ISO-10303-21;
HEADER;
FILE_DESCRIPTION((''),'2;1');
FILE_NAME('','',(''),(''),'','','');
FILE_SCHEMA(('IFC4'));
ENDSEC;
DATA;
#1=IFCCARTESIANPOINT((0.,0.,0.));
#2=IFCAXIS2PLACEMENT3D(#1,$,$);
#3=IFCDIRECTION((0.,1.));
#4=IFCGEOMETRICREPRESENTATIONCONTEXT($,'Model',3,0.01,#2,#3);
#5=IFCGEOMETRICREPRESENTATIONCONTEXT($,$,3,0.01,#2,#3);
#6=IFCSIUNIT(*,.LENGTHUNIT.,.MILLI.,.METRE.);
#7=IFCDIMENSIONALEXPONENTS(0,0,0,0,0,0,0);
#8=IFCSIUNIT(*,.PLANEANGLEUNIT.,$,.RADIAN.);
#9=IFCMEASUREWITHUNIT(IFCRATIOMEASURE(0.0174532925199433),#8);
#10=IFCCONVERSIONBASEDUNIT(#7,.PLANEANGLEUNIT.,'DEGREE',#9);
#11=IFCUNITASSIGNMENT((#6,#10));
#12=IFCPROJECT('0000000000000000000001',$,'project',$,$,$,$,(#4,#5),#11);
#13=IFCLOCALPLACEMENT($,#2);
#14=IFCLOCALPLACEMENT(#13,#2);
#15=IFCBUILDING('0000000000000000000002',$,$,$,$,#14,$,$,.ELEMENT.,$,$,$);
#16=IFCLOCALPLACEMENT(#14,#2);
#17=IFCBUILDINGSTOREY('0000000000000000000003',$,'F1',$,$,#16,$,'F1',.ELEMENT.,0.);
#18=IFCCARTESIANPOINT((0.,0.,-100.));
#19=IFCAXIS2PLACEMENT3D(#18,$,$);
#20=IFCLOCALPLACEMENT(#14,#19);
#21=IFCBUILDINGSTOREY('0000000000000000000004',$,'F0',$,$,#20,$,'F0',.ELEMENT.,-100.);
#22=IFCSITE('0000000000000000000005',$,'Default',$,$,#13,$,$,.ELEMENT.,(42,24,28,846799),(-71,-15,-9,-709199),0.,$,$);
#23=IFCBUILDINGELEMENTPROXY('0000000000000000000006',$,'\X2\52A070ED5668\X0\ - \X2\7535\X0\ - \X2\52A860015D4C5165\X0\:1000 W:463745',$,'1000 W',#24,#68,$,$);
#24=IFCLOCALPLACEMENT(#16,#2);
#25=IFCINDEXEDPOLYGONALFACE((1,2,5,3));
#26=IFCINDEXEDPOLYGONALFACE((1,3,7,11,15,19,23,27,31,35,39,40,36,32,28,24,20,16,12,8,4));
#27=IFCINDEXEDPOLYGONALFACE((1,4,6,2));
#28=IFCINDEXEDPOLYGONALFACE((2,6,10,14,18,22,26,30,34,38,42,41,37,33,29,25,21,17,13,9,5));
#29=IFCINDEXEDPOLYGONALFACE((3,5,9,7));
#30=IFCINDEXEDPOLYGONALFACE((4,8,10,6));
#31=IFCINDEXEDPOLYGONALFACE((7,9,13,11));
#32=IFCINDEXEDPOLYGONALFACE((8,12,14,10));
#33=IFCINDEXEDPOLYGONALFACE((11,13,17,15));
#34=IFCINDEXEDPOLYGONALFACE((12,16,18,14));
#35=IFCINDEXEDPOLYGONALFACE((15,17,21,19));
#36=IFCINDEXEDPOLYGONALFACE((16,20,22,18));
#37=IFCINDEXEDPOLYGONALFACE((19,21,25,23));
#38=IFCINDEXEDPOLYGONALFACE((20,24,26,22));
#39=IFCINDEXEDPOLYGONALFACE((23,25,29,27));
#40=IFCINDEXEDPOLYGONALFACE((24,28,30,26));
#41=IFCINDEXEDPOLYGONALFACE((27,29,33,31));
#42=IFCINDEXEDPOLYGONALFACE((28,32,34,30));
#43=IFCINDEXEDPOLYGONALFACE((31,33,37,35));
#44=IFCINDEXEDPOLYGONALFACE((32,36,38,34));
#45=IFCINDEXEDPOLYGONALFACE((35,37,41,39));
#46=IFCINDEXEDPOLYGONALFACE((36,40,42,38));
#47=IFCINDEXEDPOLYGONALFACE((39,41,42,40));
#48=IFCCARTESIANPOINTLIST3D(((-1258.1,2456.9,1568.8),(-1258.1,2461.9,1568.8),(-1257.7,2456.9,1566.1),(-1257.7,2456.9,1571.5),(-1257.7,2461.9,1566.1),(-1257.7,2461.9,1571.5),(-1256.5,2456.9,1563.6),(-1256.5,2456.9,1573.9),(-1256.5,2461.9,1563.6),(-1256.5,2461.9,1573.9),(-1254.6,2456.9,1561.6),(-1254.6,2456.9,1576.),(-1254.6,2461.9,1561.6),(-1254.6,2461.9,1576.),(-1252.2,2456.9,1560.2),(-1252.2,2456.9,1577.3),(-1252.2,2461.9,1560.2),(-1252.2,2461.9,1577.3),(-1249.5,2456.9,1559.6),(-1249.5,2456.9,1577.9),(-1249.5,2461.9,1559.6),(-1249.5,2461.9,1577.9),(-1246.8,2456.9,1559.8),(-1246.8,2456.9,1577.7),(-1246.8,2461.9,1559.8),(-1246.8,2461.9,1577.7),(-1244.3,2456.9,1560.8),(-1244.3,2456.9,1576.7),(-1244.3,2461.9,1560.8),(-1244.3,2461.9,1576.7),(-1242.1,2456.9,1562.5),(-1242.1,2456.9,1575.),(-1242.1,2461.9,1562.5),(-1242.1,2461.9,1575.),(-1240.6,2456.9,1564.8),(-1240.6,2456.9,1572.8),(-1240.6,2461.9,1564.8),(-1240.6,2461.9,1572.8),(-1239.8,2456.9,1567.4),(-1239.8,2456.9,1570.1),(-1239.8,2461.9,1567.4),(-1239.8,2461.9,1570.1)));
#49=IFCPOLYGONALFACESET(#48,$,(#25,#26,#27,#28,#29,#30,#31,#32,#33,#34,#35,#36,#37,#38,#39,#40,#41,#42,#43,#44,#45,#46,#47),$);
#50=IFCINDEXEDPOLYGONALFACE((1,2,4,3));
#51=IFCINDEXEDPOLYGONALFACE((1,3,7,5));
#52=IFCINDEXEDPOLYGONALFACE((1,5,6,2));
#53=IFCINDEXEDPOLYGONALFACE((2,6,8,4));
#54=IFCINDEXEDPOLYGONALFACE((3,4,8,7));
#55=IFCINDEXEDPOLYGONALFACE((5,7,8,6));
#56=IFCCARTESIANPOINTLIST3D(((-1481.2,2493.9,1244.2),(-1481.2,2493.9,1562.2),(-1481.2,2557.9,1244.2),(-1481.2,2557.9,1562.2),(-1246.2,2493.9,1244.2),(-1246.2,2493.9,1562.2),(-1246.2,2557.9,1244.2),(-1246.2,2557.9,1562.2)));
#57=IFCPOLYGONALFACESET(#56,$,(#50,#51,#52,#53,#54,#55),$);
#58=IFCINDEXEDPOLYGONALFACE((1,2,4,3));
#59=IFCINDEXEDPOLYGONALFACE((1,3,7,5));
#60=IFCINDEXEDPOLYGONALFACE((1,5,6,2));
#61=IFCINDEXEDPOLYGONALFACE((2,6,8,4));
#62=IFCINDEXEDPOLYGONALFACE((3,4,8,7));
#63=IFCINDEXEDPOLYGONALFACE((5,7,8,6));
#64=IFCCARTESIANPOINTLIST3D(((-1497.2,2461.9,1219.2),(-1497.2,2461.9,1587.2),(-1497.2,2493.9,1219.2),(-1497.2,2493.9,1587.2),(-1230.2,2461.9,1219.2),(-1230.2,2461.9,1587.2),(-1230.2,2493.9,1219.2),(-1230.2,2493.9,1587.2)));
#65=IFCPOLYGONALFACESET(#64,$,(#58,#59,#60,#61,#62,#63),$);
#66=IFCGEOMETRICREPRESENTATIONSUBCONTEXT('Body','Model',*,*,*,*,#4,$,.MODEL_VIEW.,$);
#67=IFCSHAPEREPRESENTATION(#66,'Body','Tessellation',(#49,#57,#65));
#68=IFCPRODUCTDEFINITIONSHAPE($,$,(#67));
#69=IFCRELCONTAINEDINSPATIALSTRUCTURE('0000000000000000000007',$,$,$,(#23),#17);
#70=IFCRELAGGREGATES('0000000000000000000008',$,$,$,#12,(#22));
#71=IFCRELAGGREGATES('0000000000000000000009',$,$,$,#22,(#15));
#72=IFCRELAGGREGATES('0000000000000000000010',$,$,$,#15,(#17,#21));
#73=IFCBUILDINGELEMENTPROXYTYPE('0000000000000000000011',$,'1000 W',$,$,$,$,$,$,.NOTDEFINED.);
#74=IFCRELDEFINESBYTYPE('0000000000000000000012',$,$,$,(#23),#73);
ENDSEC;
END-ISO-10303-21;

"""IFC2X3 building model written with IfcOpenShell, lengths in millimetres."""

from ifc_helpers import new_model, entity, si_unit, converted_unit, direction, frame, frame_2d, origin, origin_2d_with_axis, place, context, subcontext, project, spatial, rectangle, circle, extrude, source, transform, mapped, type_object, type_shapes, element, save


model = new_model("IFC2X3")

# Units and contexts
model_context = context("Model", 3, precision=0.01, world=origin(), true_north=direction((0.0, 1.0)))
context_of_model = context(None, 3, precision=0.01, world=origin(), true_north=direction((0.0, 1.0)))
body_context = subcontext(model_context, "Body", "Model", "MODEL_VIEW")
ifc_project = project(units=[si_unit("LENGTHUNIT", "METRE", prefix="MILLI"), converted_unit("PLANEANGLEUNIT", "DEGREE", entity("IfcRatioMeasure", 0.0174532925199433), si_unit("PLANEANGLEUNIT", "RADIAN"), dimensions=[0, 0, 0, 0, 0, 0, 0])], contexts=[model_context, context_of_model])

# Site, building, storey
site_placement = place(None, origin())
site = spatial("IfcSite", under=ifc_project, at=site_placement, Name="Default", CompositionType="ELEMENT", RefLatitude=(42, 24, 28, 846799), RefLongitude=(-71, -15, -9, -709199), RefElevation=0.0)
building_placement = place(site_placement, origin())
building = spatial("IfcBuilding", under=site, at=building_placement, CompositionType="ELEMENT")
storey_1_placement = place(building_placement, origin())
storey_1 = spatial("IfcBuildingStorey", under=building, at=storey_1_placement, Name="F1", LongName="F1", CompositionType="ELEMENT", Elevation=0.0)

# Shared definitions
storey_2_placement = place(building_placement, frame((0.0, 0.0, -100.0)))
storey_2 = spatial("IfcBuildingStorey", under=building, at=storey_2_placement, Name="F0", LongName="F0", CompositionType="ELEMENT", Elevation=-100.0)

# Building element proxy
building_element_proxy_type = type_object("IfcBuildingElementProxyType", Name="1000 W", PredefinedType="NOTDEFINED")
shared_shape_1 = source(origin(), body_context, "Body", "SweptSolid", [
    extrude(circle(Radius=9.2, at=origin_2d_with_axis()), frame((248.3, 349.6, 32.0), z_axis=(0.0, 0.0, 1.0), x_axis=(-1.0, 0.0, 0.0)), (0.0, 0.0, 1.0), 5.0),
    extrude(rectangle(XDim=235.0, YDim=318.0, at=frame_2d((0.0, 0.0), x_axis=(1.0, 0.0))), frame((133.5, 184.0, -64.0), z_axis=(0.0, 0.0, 1.0), x_axis=(-1.0, 0.0, 0.0)), (0.0, 0.0, 1.0), 64.0),
    extrude(rectangle(XDim=267.0, YDim=368.0, at=origin_2d_with_axis()), frame((133.5, 184.0, 0.0), z_axis=(0.0, 0.0, 1.0), x_axis=(-1.0, 0.0, 0.0)), (0.0, 0.0, 1.0), 32.0),
])
type_shapes(building_element_proxy_type, [shared_shape_1])
proxy_1_placement = place(storey_1_placement, frame((-1497.2, 2493.9, 1219.2), z_axis=(0.0, -1.0, 0.0), x_axis=(1.0, 0.0, 0.0)))
element("IfcBuildingElementProxy", 1, at=proxy_1_placement, inside=storey_1, type_object=building_element_proxy_type, Name="加热器 - 电 - 动态嵌入:1000 W:463745", ObjectType="1000 W", context=body_context, shape_type="MappedRepresentation", body=[
    mapped(shared_shape_1, transform((0.0, 0.0, 0.0), scale=1.0)),
])

save(model, "model.ifc")
